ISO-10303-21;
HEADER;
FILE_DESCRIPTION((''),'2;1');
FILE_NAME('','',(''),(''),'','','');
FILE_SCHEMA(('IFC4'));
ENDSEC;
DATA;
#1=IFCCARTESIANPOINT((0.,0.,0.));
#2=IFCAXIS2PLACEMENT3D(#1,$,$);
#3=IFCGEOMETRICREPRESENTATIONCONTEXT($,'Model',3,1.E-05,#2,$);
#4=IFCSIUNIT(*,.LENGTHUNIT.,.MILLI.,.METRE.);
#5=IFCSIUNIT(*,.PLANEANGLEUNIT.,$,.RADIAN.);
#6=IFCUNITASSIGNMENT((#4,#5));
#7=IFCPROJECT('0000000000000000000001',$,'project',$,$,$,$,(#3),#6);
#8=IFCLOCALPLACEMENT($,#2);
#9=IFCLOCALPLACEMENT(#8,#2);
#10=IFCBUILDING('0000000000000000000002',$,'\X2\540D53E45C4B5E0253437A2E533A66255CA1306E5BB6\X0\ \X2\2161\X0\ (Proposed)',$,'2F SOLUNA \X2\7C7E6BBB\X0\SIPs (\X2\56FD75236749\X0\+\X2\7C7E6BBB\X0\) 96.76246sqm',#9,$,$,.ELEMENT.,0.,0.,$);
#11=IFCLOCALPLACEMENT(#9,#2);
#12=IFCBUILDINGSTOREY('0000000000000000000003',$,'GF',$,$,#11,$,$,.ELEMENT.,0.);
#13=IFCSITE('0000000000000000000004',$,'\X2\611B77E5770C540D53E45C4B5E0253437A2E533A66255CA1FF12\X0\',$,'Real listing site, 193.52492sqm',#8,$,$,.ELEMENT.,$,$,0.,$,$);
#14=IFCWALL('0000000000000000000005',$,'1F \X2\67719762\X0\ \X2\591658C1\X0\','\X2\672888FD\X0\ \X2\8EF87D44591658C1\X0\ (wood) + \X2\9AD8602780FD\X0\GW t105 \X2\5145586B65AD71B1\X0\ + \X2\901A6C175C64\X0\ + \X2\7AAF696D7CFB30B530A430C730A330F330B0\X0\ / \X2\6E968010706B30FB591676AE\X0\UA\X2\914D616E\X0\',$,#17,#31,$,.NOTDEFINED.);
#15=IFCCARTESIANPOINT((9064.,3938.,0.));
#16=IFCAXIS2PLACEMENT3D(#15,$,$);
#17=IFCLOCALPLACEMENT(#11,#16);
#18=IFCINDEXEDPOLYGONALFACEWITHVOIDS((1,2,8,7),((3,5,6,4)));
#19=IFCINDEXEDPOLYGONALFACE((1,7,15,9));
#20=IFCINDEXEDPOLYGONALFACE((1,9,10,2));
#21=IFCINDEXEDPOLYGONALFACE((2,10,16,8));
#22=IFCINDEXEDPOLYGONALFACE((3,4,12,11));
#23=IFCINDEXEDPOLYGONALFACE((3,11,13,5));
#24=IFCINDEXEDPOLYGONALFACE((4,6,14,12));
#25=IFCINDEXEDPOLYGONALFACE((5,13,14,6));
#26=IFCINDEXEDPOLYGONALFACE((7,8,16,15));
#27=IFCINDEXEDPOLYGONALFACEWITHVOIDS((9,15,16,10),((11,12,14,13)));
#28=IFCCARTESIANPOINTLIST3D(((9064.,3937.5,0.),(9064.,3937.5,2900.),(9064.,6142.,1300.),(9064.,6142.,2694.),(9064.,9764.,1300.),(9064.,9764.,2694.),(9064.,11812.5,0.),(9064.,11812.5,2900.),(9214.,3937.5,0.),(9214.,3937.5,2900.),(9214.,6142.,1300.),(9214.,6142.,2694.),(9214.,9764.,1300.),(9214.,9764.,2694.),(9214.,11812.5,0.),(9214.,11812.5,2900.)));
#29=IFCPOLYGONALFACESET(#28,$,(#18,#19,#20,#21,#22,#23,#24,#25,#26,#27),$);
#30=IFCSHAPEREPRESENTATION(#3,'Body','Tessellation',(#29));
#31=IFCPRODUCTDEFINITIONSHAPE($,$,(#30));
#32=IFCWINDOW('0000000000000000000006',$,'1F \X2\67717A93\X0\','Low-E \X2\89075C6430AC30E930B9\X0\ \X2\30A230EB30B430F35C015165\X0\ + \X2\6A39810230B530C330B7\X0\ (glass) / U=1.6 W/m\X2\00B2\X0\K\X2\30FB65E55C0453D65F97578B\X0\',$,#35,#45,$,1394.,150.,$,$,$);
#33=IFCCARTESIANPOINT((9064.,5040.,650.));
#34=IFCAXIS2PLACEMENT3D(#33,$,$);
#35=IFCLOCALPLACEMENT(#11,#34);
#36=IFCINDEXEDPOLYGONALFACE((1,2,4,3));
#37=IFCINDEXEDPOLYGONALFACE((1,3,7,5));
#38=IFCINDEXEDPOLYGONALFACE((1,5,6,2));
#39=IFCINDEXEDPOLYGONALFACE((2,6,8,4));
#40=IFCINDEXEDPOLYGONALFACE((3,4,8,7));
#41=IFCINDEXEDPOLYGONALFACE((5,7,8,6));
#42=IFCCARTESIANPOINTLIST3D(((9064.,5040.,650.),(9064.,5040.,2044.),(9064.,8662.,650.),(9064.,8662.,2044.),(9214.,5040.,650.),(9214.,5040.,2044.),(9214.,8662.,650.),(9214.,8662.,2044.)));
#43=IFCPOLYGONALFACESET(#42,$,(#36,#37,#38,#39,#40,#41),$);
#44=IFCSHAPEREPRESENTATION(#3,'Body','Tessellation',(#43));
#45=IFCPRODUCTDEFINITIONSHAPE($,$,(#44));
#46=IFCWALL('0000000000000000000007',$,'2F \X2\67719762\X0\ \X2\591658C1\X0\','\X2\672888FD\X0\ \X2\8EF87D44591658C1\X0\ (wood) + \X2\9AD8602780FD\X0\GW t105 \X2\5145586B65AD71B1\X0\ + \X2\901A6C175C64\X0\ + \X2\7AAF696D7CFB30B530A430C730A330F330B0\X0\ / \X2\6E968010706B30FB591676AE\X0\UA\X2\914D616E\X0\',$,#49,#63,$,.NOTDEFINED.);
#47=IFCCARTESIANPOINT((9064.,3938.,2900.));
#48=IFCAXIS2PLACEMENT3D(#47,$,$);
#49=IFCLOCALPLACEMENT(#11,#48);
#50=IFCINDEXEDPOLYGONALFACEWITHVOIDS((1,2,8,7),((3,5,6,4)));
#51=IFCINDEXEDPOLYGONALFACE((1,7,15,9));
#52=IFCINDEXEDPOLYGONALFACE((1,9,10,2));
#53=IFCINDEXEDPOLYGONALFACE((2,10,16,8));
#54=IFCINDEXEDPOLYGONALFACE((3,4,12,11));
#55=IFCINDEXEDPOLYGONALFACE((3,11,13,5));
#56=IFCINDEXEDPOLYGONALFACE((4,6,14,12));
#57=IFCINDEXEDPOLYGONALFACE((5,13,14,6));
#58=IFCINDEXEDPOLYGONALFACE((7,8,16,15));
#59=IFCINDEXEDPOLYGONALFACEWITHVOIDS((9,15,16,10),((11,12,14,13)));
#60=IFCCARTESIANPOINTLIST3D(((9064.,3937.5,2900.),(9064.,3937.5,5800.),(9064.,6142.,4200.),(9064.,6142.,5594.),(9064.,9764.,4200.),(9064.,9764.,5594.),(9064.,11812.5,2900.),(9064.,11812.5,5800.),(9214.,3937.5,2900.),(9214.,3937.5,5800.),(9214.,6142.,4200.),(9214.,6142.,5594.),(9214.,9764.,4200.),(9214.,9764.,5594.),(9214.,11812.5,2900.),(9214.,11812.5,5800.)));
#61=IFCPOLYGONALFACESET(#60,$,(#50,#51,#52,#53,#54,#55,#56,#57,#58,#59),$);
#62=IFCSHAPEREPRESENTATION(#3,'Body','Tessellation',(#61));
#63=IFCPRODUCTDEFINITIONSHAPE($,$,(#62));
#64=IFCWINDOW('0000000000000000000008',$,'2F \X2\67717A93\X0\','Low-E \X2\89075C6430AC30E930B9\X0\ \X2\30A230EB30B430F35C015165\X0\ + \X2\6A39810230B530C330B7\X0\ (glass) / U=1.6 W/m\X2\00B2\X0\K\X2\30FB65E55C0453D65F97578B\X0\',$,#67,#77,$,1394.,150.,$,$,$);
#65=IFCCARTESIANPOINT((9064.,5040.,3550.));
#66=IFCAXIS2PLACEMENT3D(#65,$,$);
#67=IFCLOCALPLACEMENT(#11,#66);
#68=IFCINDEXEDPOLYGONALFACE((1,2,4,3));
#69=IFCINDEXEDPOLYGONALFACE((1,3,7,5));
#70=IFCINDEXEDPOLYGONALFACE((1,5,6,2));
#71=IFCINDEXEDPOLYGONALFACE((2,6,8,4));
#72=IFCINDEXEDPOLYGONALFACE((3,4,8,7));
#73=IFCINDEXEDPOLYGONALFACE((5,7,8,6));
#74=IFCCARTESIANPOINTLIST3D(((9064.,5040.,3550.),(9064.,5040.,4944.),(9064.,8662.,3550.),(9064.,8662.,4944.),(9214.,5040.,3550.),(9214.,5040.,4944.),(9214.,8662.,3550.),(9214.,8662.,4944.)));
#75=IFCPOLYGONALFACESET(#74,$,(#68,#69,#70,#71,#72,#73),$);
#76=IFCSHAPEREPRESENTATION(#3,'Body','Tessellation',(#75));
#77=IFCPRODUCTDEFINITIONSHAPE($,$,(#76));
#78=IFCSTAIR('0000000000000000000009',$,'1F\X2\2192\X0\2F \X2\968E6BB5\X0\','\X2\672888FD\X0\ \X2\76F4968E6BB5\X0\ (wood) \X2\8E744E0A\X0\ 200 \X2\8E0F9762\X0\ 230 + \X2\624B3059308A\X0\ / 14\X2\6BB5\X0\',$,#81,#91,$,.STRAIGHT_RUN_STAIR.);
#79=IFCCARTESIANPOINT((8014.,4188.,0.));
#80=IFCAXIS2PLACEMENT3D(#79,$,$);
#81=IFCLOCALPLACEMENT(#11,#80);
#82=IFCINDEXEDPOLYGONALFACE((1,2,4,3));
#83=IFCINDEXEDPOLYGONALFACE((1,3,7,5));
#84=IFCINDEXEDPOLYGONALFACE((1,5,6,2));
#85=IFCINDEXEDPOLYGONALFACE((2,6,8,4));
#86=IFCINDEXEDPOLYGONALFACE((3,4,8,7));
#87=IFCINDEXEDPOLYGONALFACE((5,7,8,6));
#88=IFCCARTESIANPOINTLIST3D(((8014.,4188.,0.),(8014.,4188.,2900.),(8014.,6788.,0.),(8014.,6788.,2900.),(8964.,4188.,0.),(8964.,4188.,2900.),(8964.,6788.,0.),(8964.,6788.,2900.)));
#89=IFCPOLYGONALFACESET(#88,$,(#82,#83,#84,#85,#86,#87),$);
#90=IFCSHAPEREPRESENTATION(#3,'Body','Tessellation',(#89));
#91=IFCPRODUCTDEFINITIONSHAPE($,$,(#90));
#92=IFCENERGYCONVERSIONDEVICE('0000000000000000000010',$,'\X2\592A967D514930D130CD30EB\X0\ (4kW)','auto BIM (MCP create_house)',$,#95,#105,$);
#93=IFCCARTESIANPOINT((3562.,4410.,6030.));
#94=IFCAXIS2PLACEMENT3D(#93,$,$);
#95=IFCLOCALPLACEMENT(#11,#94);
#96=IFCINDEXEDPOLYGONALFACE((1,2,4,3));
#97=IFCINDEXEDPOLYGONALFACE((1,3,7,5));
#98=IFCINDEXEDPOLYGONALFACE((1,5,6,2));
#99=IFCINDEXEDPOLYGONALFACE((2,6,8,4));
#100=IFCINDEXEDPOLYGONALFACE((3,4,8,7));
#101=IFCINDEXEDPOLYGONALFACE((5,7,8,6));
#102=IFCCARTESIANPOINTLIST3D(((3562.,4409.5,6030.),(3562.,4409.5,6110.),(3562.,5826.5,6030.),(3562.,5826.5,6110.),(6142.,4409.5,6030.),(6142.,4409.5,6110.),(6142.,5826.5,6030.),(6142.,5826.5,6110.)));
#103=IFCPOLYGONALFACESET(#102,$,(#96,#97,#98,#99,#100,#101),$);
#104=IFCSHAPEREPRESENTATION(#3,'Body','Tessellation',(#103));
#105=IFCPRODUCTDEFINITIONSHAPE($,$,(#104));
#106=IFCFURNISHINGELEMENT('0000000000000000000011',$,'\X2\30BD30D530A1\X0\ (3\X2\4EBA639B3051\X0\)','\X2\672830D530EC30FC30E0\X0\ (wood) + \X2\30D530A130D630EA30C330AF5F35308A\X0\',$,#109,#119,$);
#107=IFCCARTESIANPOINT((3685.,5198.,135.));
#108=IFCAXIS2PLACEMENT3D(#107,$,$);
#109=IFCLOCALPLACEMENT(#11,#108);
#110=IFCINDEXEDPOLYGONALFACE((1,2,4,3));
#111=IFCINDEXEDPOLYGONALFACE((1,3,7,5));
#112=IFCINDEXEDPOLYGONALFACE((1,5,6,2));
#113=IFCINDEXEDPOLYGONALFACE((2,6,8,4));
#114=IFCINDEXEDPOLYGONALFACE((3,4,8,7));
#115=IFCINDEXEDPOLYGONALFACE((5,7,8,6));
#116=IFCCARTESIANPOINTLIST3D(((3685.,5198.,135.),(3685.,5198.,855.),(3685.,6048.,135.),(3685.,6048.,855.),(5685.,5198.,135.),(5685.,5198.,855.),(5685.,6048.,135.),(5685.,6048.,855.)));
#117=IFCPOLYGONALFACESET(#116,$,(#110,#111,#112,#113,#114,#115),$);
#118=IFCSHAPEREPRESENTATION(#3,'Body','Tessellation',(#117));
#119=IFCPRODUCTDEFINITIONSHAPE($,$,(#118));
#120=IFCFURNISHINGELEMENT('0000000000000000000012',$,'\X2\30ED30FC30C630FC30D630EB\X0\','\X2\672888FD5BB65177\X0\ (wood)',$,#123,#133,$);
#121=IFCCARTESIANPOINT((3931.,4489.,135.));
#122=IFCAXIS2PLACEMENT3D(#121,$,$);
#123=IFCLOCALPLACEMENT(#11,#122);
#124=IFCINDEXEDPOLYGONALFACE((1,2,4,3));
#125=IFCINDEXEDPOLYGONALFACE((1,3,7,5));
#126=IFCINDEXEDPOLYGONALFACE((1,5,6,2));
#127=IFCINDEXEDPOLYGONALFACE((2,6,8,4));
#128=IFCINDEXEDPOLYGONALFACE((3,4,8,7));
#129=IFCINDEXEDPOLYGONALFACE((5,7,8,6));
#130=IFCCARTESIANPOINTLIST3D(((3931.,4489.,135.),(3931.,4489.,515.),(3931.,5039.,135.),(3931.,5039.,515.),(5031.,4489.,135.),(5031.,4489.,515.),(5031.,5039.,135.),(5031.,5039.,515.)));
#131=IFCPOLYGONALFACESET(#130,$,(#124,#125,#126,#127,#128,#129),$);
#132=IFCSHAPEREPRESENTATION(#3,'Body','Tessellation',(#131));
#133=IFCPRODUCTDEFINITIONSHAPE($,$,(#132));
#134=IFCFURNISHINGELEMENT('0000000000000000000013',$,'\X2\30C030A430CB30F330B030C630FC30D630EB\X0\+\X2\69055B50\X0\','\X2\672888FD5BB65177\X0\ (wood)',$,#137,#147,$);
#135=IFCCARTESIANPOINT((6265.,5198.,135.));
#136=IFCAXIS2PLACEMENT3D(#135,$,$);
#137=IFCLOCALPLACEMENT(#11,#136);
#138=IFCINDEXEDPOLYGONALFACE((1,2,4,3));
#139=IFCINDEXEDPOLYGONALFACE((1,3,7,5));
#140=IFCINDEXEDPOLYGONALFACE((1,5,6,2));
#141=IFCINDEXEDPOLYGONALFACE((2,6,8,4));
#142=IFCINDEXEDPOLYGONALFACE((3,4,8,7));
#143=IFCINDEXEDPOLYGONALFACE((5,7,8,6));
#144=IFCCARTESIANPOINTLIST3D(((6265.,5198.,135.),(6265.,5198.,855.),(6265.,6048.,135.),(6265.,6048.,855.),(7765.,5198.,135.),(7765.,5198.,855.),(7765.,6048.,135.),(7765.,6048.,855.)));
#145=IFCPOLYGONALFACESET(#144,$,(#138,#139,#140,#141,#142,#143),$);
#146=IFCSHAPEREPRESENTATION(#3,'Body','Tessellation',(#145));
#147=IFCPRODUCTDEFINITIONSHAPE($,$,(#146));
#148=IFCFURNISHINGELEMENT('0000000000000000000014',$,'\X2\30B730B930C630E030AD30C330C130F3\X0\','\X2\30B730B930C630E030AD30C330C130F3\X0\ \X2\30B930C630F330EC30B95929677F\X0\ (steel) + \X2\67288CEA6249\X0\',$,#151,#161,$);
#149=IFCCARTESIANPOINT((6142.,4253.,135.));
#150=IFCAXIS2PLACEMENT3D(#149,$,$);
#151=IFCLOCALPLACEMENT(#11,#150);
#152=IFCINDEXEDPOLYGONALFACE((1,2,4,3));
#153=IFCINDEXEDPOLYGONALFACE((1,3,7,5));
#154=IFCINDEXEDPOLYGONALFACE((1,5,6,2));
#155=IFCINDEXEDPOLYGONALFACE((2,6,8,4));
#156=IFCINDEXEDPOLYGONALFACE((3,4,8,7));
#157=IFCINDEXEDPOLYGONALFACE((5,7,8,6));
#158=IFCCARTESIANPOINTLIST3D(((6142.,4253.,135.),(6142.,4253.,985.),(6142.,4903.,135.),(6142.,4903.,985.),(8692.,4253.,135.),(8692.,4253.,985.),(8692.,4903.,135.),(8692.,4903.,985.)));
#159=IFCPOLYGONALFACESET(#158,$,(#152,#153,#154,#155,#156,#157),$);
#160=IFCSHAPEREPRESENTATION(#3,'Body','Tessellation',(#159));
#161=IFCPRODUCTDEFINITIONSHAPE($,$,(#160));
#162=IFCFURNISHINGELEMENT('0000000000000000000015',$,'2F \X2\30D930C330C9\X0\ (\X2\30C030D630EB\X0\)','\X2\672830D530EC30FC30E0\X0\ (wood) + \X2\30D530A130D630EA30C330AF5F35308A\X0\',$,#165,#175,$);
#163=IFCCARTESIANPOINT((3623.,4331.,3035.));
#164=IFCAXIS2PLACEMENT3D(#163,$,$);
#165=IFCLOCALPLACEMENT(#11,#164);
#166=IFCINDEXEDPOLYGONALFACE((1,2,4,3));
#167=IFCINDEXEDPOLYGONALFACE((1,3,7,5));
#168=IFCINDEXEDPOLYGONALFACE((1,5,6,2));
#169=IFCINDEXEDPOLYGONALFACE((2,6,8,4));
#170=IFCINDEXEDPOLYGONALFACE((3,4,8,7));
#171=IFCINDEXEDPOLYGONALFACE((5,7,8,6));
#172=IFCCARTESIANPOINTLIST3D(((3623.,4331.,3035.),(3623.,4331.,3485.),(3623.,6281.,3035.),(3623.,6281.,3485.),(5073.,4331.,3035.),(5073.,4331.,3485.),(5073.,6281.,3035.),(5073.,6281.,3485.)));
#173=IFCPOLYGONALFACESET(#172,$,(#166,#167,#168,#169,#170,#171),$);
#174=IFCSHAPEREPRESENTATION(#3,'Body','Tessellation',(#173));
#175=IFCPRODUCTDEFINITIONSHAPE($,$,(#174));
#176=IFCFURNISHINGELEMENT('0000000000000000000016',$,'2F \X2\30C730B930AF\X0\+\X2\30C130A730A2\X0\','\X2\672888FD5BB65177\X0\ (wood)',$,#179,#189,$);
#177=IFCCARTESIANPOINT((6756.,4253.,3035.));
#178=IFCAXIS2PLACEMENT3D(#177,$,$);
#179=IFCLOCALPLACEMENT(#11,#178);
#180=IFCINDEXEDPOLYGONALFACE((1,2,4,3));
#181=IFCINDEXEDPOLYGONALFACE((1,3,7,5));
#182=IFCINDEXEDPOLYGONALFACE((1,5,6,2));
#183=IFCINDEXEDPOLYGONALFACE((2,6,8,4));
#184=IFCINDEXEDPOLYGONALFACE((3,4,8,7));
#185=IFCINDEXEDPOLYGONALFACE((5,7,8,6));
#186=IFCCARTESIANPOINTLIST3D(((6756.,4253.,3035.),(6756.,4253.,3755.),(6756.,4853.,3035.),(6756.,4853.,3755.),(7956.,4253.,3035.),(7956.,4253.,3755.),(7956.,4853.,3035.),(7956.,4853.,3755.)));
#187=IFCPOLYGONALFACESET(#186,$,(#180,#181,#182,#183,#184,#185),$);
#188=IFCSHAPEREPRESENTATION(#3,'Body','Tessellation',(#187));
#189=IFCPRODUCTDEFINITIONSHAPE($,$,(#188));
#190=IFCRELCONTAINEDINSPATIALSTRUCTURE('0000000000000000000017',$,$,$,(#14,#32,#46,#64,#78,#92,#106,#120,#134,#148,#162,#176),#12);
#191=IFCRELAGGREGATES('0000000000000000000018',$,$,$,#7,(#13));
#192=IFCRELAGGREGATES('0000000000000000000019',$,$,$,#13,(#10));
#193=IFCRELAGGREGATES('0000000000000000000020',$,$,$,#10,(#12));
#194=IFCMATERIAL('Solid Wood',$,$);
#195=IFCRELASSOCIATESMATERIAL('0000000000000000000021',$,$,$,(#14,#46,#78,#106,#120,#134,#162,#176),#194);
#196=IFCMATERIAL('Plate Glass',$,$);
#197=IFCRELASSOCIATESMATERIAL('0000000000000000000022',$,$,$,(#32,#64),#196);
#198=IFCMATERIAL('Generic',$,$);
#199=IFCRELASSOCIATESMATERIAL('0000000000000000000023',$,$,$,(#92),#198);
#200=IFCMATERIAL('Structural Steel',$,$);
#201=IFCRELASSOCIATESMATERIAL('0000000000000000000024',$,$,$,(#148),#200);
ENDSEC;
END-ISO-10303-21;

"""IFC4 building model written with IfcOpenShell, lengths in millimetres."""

from ifc_helpers import new_model, si_unit, frame, frame_2d, origin, place, context, project, spatial, rectangle, extrude, material, element, fill, save


model = new_model("IFC4")

# Units and contexts
model_context = context("Model", 3, precision=1e-05, world=origin())
ifc_project = project(units=[si_unit("LENGTHUNIT", "METRE", prefix="MILLI"), si_unit("PLANEANGLEUNIT", "RADIAN")], contexts=[model_context])

# Site, building, storey
site_placement = place(None, origin())
site = spatial("IfcSite", under=ifc_project, at=site_placement, Name="愛知県名古屋市千種区春岡２", ObjectType="Real listing site, 193.52492sqm", CompositionType="ELEMENT", RefElevation=0.0)
building_placement = place(site_placement, origin())
building = spatial("IfcBuilding", under=site, at=building_placement, Name="名古屋市千種区春岡の家 Ⅱ (Proposed)", ObjectType="2F SOLUNA 籾殻SIPs (国産杉+籾殻) 96.76246sqm", CompositionType="ELEMENT", ElevationOfRefHeight=0.0, ElevationOfTerrain=0.0)
storey_placement = place(building_placement, origin())
storey = spatial("IfcBuildingStorey", under=building, at=storey_placement, Name="GF", CompositionType="ELEMENT", Elevation=0.0)

# Wall, opening, window
ifc_material_1 = material(Name="Solid Wood")
wall_1_placement = place(storey_placement, frame((9064.0, 3938.0, 0.0)))
wall_1 = element("IfcWall", 1, at=wall_1_placement, inside=storey, material=ifc_material_1, Name="1F 東面 外壁", Description="木製 軸組外壁 (wood) + 高性能GW t105 充填断熱 + 通気層 + 窯業系サイディング / 準耐火・外皮UA配慮", PredefinedType="NOTDEFINED", context=model_context, shape_type="SweptSolid", body=[
    extrude(rectangle(XDim=150.0, YDim=7875.0, at=frame_2d((75.0, 3937.0))), frame((9064.0, 3938.0, 0.0)), (0.0, 0.0, 1.0), 2900.0),
])
opening_1_placement = place(storey_placement, frame((9064.0, 5040.0, 650.0)))
opening_1 = element("IfcOpeningElement", 2, at=opening_1_placement, cuts=wall_1, PredefinedType="NOTDEFINED", context=model_context, shape_type="SweptSolid", body=[
    extrude(rectangle(XDim=150.0, YDim=3622.0, at=frame_2d((75.0, 1811.0))), frame((9064.0, 5040.0, 650.0)), (0.0, 0.0, 1.0), 1394.0),
])
ifc_material_2 = material(Name="Plate Glass")
window_1_placement = place(storey_placement, frame((9064.0, 5040.0, 650.0)))
window_1 = element("IfcWindow", 3, at=window_1_placement, inside=storey, material=ifc_material_2, Name="1F 東窓", Description="Low-E 複層ガラス アルゴン封入 + 樹脂サッシ (glass) / U=1.6 W/m²K・日射取得型", OverallHeight=1394.0, OverallWidth=150.0, context=model_context, shape_type="SweptSolid", body=[
    extrude(rectangle(XDim=150.0, YDim=3622.0, at=frame_2d((75.0, 1811.0))), frame((9064.0, 5040.0, 650.0)), (0.0, 0.0, 1.0), 1394.0),
])
fill(opening_1, window_1)

# Wall, opening, window
wall_2_placement = place(storey_placement, frame((9064.0, 3938.0, 2900.0)))
wall_2 = element("IfcWall", 4, at=wall_2_placement, inside=storey, material=ifc_material_1, Name="2F 東面 外壁", Description="木製 軸組外壁 (wood) + 高性能GW t105 充填断熱 + 通気層 + 窯業系サイディング / 準耐火・外皮UA配慮", PredefinedType="NOTDEFINED", context=model_context, shape_type="SweptSolid", body=[
    extrude(rectangle(XDim=150.0, YDim=7875.0, at=frame_2d((75.0, 3937.0))), frame((9064.0, 3938.0, 2900.0)), (0.0, 0.0, 1.0), 2900.0),
])
opening_2_placement = place(storey_placement, frame((9064.0, 5040.0, 3550.0)))
opening_2 = element("IfcOpeningElement", 5, at=opening_2_placement, cuts=wall_2, PredefinedType="NOTDEFINED", context=model_context, shape_type="SweptSolid", body=[
    extrude(rectangle(XDim=150.0, YDim=3622.0, at=frame_2d((75.0, 1811.0))), frame((9064.0, 5040.0, 3550.0)), (0.0, 0.0, 1.0), 1394.0),
])
window_2_placement = place(storey_placement, frame((9064.0, 5040.0, 3550.0)))
window_2 = element("IfcWindow", 6, at=window_2_placement, inside=storey, material=ifc_material_2, Name="2F 東窓", Description="Low-E 複層ガラス アルゴン封入 + 樹脂サッシ (glass) / U=1.6 W/m²K・日射取得型", OverallHeight=1394.0, OverallWidth=150.0, context=model_context, shape_type="SweptSolid", body=[
    extrude(rectangle(XDim=150.0, YDim=3622.0, at=frame_2d((75.0, 1811.0))), frame((9064.0, 5040.0, 3550.0)), (0.0, 0.0, 1.0), 1394.0),
])
fill(opening_2, window_2)

# Stair
stair_placement = place(storey_placement, frame((8014.0, 4188.0, 0.0)))
element("IfcStair", 7, at=stair_placement, inside=storey, material=ifc_material_1, Name="1F→2F 階段", Description="木製 直階段 (wood) 蹴上 200 踏面 230 + 手すり / 14段", PredefinedType="STRAIGHT_RUN_STAIR", context=model_context, shape_type="SweptSolid", body=[
    extrude(rectangle(XDim=950.0, YDim=2600.0, at=frame_2d((475.0, 1300.0))), frame((8014.0, 4188.0, 0.0)), (0.0, 0.0, 1.0), 2900.0),
])

# Energy conversion device
ifc_material_3 = material(Name="Generic")
energy_conversion_device_placement = place(storey_placement, frame((3562.0, 4410.0, 6030.0)))
element("IfcEnergyConversionDevice", 8, at=energy_conversion_device_placement, inside=storey, material=ifc_material_3, Name="太陽光パネル (4kW)", Description="auto BIM (MCP create_house)", context=model_context, shape_type="SweptSolid", body=[
    extrude(rectangle(XDim=2580.0, YDim=1417.0, at=frame_2d((1290.0, 708.0))), frame((3562.0, 4410.0, 6030.0)), (0.0, 0.0, 1.0), 80.0),
])

# Furnishing elements
furnishing_1_placement = place(storey_placement, frame((3685.0, 5198.0, 135.0)))
element("IfcFurnishingElement", 9, at=furnishing_1_placement, inside=storey, material=ifc_material_1, Name="ソファ (3人掛け)", Description="木フレーム (wood) + ファブリック張り", context=model_context, shape_type="SweptSolid", body=[
    extrude(rectangle(XDim=2000.0, YDim=850.0, at=frame_2d((1000.0, 425.0))), frame((3685.0, 5198.0, 135.0)), (0.0, 0.0, 1.0), 720.0),
])
furnishing_2_placement = place(storey_placement, frame((3931.0, 4489.0, 135.0)))
element("IfcFurnishingElement", 10, at=furnishing_2_placement, inside=storey, material=ifc_material_1, Name="ローテーブル", Description="木製家具 (wood)", context=model_context, shape_type="SweptSolid", body=[
    extrude(rectangle(XDim=1100.0, YDim=550.0, at=frame_2d((550.0, 275.0))), frame((3931.0, 4489.0, 135.0)), (0.0, 0.0, 1.0), 380.0),
])
furnishing_3_placement = place(storey_placement, frame((6265.0, 5198.0, 135.0)))
element("IfcFurnishingElement", 11, at=furnishing_3_placement, inside=storey, material=ifc_material_1, Name="ダイニングテーブル+椅子", Description="木製家具 (wood)", context=model_context, shape_type="SweptSolid", body=[
    extrude(rectangle(XDim=1500.0, YDim=850.0, at=frame_2d((750.0, 425.0))), frame((6265.0, 5198.0, 135.0)), (0.0, 0.0, 1.0), 720.0),
])
ifc_material_4 = material(Name="Structural Steel")
furnishing_4_placement = place(storey_placement, frame((6142.0, 4253.0, 135.0)))
element("IfcFurnishingElement", 12, at=furnishing_4_placement, inside=storey, material=ifc_material_4, Name="システムキッチン", Description="システムキッチン ステンレス天板 (steel) + 木質扉", context=model_context, shape_type="SweptSolid", body=[
    extrude(rectangle(XDim=2550.0, YDim=650.0, at=frame_2d((1275.0, 325.0))), frame((6142.0, 4253.0, 135.0)), (0.0, 0.0, 1.0), 850.0),
])
furnishing_5_placement = place(storey_placement, frame((3623.0, 4331.0, 3035.0)))
element("IfcFurnishingElement", 13, at=furnishing_5_placement, inside=storey, material=ifc_material_1, Name="2F ベッド (ダブル)", Description="木フレーム (wood) + ファブリック張り", context=model_context, shape_type="SweptSolid", body=[
    extrude(rectangle(XDim=1450.0, YDim=1950.0, at=frame_2d((725.0, 975.0))), frame((3623.0, 4331.0, 3035.0)), (0.0, 0.0, 1.0), 450.0),
])
furnishing_6_placement = place(storey_placement, frame((6756.0, 4253.0, 3035.0)))
element("IfcFurnishingElement", 14, at=furnishing_6_placement, inside=storey, material=ifc_material_1, Name="2F デスク+チェア", Description="木製家具 (wood)", context=model_context, shape_type="SweptSolid", body=[
    extrude(rectangle(XDim=1200.0, YDim=600.0, at=frame_2d((600.0, 300.0))), frame((6756.0, 4253.0, 3035.0)), (0.0, 0.0, 1.0), 720.0),
])

save(model, "model.ifc")
